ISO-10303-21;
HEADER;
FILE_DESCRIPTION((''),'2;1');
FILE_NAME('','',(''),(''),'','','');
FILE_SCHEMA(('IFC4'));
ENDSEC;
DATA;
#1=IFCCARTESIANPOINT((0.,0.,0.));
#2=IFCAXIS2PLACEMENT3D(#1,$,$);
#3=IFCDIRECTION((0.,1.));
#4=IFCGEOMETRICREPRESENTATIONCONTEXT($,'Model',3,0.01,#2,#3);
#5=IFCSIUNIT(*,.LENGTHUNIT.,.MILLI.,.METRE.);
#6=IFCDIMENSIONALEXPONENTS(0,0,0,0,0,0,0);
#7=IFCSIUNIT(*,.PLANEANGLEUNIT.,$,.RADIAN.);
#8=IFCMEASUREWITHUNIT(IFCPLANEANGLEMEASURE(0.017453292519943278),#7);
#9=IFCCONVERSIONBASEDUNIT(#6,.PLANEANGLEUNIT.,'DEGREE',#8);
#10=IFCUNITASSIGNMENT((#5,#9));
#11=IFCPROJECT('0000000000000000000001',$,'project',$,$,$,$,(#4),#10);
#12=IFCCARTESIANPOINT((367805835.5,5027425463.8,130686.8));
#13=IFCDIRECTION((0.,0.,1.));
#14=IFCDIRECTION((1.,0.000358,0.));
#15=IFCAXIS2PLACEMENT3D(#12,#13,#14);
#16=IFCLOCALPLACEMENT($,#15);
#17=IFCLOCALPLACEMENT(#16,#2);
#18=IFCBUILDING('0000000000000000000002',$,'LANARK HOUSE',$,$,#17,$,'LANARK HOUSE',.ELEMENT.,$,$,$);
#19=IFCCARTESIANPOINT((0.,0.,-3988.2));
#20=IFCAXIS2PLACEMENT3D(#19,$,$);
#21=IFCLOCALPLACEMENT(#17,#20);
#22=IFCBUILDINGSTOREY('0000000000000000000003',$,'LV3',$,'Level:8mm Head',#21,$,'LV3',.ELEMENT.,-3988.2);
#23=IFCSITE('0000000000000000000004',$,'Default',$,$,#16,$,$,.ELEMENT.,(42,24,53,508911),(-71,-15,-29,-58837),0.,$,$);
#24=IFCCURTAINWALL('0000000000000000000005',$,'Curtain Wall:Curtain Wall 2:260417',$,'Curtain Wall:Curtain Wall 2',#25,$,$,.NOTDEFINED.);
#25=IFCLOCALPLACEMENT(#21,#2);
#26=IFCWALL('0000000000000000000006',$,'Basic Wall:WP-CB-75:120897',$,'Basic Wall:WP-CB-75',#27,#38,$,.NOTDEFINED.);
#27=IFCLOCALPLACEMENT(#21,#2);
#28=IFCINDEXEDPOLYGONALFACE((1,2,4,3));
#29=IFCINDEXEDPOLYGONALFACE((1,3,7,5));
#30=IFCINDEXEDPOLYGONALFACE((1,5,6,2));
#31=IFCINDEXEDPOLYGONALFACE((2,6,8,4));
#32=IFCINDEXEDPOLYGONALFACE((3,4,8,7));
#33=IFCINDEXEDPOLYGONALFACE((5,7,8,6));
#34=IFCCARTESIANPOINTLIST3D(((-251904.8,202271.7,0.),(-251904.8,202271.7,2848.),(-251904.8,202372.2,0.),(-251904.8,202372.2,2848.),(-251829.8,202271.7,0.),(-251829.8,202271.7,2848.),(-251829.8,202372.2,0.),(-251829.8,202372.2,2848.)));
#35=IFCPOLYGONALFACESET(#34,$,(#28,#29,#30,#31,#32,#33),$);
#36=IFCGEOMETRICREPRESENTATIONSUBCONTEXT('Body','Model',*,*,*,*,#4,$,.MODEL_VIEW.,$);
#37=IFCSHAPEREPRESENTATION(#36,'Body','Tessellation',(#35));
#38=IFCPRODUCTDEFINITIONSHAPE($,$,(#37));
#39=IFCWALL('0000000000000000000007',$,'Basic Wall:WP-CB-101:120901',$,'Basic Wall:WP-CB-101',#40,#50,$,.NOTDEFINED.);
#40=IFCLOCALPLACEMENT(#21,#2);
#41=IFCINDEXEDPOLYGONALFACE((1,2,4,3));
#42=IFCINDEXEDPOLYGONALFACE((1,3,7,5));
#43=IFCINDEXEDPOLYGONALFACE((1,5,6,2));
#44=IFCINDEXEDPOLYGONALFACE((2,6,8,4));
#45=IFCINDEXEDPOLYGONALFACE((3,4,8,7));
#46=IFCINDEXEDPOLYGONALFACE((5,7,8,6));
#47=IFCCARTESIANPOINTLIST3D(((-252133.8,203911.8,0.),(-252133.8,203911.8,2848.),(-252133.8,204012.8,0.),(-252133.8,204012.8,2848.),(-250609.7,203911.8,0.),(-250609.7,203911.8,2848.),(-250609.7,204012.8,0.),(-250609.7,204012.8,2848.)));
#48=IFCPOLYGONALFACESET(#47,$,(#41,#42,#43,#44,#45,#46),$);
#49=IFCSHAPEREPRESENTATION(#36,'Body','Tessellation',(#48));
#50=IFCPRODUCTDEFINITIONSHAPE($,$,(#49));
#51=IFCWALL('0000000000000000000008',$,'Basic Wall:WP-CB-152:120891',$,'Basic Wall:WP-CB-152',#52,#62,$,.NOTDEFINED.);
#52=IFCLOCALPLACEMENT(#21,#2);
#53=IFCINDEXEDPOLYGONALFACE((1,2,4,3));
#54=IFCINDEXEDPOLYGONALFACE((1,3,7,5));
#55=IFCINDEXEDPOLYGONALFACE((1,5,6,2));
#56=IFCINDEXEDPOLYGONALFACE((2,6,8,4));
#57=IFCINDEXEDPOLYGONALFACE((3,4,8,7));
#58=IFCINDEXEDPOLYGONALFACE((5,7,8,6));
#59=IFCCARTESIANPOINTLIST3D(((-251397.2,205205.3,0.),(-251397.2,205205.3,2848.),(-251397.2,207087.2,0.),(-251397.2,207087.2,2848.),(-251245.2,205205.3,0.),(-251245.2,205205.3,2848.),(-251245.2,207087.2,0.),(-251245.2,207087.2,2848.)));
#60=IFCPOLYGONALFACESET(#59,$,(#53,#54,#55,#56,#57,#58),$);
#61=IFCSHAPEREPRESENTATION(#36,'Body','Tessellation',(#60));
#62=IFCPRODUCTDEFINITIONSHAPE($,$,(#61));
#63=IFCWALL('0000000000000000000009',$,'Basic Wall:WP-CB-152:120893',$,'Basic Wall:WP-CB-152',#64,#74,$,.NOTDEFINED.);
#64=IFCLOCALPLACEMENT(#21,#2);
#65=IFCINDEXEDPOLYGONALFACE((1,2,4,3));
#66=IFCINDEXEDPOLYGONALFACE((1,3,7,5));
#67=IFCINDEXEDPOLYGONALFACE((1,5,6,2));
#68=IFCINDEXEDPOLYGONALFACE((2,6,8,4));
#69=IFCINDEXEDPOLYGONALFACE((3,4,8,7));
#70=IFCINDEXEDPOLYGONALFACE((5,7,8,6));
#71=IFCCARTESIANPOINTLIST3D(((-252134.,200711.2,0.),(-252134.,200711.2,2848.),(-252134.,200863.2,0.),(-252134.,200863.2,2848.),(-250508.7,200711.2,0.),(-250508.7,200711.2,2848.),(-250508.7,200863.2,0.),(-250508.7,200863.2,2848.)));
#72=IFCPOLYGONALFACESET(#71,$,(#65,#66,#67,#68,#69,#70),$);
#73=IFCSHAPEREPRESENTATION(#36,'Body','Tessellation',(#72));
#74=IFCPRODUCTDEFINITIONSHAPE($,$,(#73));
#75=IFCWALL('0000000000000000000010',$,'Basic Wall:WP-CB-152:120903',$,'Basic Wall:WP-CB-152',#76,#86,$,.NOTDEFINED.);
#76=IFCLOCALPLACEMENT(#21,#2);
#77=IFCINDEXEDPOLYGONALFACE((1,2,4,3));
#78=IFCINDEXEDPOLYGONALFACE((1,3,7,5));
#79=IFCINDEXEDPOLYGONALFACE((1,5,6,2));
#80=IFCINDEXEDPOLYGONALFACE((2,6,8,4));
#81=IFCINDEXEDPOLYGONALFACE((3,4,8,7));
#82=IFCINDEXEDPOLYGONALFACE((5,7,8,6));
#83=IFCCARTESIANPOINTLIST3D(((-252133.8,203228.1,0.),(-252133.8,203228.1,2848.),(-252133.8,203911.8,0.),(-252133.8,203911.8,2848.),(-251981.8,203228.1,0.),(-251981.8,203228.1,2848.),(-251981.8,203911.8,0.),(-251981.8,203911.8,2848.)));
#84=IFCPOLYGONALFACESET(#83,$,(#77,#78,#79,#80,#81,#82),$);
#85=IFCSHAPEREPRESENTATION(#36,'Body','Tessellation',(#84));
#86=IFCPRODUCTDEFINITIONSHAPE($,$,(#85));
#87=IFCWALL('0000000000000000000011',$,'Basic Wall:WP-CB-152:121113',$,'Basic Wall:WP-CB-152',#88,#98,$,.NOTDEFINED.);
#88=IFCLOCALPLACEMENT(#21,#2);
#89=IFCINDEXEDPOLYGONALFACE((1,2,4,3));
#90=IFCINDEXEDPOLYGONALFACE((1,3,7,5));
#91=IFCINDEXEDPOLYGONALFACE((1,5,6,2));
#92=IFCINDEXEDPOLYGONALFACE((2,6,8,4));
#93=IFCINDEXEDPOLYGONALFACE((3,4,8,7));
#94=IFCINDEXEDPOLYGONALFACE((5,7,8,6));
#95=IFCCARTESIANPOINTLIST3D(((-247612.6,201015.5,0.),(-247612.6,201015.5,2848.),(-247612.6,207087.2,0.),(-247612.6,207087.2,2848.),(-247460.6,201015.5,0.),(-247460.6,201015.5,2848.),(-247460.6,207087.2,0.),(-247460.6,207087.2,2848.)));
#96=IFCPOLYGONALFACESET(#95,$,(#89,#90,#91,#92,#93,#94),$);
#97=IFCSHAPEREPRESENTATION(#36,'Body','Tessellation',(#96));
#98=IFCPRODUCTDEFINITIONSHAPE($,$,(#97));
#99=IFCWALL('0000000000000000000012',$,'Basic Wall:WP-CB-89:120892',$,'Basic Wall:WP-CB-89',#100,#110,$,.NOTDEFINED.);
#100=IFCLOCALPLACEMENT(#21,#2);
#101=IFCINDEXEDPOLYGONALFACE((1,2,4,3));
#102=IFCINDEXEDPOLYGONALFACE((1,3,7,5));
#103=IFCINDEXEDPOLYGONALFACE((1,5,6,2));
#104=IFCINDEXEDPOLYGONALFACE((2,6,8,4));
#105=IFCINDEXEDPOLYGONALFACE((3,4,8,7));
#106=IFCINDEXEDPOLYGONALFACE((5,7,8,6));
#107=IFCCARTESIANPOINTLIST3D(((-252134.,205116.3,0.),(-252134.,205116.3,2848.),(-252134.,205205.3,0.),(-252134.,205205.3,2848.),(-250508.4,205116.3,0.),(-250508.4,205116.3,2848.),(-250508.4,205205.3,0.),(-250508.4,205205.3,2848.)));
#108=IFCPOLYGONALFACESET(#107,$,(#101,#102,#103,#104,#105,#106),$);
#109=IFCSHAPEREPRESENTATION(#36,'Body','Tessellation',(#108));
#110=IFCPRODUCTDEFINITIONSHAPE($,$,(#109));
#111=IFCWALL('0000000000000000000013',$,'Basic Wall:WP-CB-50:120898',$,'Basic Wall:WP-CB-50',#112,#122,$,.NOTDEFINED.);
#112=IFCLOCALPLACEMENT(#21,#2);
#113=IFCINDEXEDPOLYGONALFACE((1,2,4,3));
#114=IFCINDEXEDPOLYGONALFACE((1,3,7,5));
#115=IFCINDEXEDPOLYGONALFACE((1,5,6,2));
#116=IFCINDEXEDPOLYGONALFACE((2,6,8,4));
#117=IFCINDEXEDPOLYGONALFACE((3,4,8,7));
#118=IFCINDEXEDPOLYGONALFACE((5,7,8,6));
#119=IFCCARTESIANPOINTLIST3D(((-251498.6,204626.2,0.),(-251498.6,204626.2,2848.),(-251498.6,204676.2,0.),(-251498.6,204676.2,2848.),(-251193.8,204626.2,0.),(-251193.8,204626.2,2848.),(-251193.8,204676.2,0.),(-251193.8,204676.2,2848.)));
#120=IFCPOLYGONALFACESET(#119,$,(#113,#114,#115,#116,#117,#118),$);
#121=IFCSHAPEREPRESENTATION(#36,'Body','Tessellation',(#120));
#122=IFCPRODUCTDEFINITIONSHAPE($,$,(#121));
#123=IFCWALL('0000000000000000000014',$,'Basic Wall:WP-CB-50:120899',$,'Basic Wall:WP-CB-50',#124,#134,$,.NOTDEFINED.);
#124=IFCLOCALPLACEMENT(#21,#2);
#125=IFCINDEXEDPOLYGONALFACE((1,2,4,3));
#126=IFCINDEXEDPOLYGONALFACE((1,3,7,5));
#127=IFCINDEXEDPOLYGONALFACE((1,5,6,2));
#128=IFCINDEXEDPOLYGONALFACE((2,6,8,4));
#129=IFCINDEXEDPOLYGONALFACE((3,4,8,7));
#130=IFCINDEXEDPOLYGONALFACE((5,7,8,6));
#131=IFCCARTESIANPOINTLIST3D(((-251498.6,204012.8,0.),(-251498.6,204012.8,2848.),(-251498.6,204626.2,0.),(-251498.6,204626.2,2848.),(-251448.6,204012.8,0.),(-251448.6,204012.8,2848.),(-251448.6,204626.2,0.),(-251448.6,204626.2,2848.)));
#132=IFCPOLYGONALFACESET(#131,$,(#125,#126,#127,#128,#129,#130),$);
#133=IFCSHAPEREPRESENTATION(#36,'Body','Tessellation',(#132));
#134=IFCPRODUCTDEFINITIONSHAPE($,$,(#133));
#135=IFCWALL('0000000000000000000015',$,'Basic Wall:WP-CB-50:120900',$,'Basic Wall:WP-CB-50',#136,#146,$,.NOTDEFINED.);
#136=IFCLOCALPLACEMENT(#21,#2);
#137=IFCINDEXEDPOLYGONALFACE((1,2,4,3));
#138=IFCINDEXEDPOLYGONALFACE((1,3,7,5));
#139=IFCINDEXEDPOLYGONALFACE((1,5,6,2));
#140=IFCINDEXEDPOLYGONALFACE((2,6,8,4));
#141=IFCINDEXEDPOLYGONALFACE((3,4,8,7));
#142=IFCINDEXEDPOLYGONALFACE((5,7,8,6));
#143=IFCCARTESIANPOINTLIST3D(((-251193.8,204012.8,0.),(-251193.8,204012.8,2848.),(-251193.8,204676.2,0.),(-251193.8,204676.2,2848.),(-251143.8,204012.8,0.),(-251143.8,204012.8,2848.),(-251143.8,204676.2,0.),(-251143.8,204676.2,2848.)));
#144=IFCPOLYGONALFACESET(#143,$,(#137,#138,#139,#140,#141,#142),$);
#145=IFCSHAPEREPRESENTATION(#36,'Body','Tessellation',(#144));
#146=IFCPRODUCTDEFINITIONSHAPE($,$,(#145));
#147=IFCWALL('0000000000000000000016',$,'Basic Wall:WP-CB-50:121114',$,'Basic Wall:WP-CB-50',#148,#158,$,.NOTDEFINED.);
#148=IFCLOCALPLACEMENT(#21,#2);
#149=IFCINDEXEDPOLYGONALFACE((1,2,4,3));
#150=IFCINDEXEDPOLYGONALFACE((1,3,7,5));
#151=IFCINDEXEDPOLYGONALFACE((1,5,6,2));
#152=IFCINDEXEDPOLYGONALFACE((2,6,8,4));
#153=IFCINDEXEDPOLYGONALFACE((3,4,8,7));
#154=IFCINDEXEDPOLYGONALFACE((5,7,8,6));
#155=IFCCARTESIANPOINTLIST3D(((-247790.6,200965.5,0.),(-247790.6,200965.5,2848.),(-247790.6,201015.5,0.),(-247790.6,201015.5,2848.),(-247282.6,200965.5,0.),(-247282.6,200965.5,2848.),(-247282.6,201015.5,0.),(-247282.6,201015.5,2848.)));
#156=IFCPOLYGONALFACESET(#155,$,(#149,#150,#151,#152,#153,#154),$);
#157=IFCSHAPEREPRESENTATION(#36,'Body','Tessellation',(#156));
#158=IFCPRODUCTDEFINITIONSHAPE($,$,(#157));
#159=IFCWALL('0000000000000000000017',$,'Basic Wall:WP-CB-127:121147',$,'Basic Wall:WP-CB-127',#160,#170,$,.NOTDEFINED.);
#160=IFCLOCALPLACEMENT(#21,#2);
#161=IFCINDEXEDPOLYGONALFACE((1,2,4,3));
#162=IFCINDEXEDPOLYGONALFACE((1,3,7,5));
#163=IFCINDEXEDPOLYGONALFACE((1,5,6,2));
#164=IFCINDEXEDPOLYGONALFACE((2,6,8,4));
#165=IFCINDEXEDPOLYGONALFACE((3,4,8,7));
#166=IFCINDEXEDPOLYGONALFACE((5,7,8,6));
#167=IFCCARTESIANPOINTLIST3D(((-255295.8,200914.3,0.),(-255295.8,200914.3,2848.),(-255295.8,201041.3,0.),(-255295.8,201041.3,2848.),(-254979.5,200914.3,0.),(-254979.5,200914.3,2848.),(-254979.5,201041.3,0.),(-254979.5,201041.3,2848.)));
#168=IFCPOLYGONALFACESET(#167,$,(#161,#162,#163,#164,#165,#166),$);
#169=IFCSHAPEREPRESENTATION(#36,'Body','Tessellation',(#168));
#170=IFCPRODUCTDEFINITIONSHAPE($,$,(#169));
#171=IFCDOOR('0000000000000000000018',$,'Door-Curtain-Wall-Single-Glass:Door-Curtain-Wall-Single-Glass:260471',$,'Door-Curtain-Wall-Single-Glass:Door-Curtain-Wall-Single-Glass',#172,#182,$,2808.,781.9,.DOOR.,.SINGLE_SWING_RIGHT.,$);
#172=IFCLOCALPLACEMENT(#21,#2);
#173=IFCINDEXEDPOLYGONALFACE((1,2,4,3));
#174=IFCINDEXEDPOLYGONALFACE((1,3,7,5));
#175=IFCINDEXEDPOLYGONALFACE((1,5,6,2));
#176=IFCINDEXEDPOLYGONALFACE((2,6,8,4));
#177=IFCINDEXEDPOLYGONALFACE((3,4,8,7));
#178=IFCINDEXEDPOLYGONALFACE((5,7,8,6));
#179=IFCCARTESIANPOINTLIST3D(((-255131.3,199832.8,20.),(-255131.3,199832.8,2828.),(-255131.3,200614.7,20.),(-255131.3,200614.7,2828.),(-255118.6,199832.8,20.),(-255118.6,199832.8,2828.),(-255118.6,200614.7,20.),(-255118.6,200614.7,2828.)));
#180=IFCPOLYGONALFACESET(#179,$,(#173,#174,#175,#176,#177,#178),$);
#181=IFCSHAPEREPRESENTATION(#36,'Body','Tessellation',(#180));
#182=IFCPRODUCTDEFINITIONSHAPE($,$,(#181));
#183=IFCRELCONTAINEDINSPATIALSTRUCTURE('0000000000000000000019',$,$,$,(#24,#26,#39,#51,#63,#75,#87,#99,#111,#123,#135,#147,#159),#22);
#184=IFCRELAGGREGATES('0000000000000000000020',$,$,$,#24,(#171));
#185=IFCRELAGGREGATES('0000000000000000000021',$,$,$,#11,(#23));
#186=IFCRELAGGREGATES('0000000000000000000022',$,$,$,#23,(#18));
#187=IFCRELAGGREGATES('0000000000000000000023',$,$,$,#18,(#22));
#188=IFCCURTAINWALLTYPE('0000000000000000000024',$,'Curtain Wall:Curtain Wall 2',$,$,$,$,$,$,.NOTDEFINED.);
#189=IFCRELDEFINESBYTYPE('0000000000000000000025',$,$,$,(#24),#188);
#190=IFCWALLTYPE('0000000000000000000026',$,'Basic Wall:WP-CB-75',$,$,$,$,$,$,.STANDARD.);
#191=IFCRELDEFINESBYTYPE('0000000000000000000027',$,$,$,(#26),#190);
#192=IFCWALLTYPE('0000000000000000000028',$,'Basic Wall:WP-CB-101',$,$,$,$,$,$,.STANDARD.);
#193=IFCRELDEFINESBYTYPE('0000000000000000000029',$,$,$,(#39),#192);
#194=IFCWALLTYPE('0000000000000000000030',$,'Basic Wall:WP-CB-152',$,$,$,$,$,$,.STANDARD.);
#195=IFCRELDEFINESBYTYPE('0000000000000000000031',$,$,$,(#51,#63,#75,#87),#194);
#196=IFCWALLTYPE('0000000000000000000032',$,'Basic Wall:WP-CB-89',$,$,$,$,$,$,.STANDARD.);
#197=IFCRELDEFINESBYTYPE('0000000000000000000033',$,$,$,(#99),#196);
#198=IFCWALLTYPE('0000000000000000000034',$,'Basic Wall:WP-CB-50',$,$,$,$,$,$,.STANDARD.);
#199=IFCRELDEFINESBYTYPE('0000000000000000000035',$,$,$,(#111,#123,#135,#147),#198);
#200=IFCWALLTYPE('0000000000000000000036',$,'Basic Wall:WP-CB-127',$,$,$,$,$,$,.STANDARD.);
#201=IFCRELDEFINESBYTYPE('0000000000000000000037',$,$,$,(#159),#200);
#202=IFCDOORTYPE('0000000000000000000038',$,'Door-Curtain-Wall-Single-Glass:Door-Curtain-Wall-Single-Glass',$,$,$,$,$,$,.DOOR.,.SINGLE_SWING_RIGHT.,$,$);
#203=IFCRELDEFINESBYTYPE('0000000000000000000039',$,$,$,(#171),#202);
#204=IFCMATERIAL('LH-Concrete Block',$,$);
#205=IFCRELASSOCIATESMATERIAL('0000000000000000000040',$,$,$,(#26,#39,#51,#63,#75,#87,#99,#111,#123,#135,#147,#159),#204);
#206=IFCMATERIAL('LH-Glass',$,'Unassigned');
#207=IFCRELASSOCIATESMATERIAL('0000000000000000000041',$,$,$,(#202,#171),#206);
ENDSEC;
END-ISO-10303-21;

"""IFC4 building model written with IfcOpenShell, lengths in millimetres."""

from ifc_helpers import new_model, entity, si_unit, converted_unit, direction, frame, origin, place, context, subcontext, project, spatial, indexed_curve, outline, extrude, source, transform, mapped, material, type_object, type_shapes, element, aggregate, save


model = new_model("IFC4")

# Units and contexts
model_context = context("Model", 3, precision=0.01, world=origin(), true_north=direction((0.0, 1.0)))
body_context = subcontext(model_context, "Body", "Model", "MODEL_VIEW")
ifc_project = project(units=[si_unit("LENGTHUNIT", "METRE", prefix="MILLI"), converted_unit("PLANEANGLEUNIT", "DEGREE", entity("IfcPlaneAngleMeasure", 0.017453292519943278), si_unit("PLANEANGLEUNIT", "RADIAN"), dimensions=[0, 0, 0, 0, 0, 0, 0])], contexts=[model_context])

# Site, building, storey
site_placement = place(None, frame((367805835.5, 5027425463.8, 130686.8), z_axis=(0.0, 0.0, 1.0), x_axis=(1.0, 0.000358, 0.0)))
site = spatial("IfcSite", under=ifc_project, at=site_placement, Name="Default", CompositionType="ELEMENT", RefLatitude=(42, 24, 53, 508911), RefLongitude=(-71, -15, -29, -58837), RefElevation=0.0)
building_placement = place(site_placement, origin())
building = spatial("IfcBuilding", under=site, at=building_placement, Name="LANARK HOUSE", LongName="LANARK HOUSE", CompositionType="ELEMENT")
storey_placement = place(building_placement, frame((0.0, 0.0, -3988.2)))
storey = spatial("IfcBuildingStorey", under=building, at=storey_placement, Name="LV3", ObjectType="Level:8mm Head", LongName="LV3", CompositionType="ELEMENT", Elevation=-3988.2)

# Curtain wall
curtain_wall_type = type_object("IfcCurtainWallType", Name="Curtain Wall:Curtain Wall 2", PredefinedType="NOTDEFINED")
curtain_wall_placement = place(storey_placement, frame((0.0, 0.0, 3988.2)))
curtain_wall = element("IfcCurtainWall", 1, at=curtain_wall_placement, inside=storey, type_object=curtain_wall_type, Name="Curtain Wall:Curtain Wall 2:260417", ObjectType="Curtain Wall:Curtain Wall 2", PredefinedType="NOTDEFINED")

# Walls
ifc_material_1 = material(Name="LH-Concrete Block")
wall_type_1 = type_object("IfcWallType", Name="Basic Wall:WP-CB-75", PredefinedType="STANDARD")
wall_1_placement = place(storey_placement, frame((-251867.3, 202372.2, 0.0), z_axis=(0.0, 0.0, 1.0), x_axis=(0.0, -1.0, 0.0)))
element("IfcWall", 2, at=wall_1_placement, inside=storey, type_object=wall_type_1, material=ifc_material_1, Name="Basic Wall:WP-CB-75:120897", ObjectType="Basic Wall:WP-CB-75", PredefinedType="NOTDEFINED", context=body_context, shape_type="SweptSolid", body=[
    extrude(outline(indexed_curve([(100.5, 37.5), (0.0, 37.5), (0.0, -37.5), (100.5, -37.5), (100.5, 37.5)], self_intersect=False)), origin(), (0.0, 0.0, 1.0), 2848.0),
])
wall_type_2 = type_object("IfcWallType", Name="Basic Wall:WP-CB-101", PredefinedType="STANDARD")
wall_2_placement = place(storey_placement, frame((-250609.7, 203962.3, 0.0), z_axis=(0.0, 0.0, 1.0), x_axis=(-1.0, 0.0, 0.0)))
element("IfcWall", 3, at=wall_2_placement, inside=storey, type_object=wall_type_2, material=ifc_material_1, Name="Basic Wall:WP-CB-101:120901", ObjectType="Basic Wall:WP-CB-101", PredefinedType="NOTDEFINED", context=body_context, shape_type="SweptSolid", body=[
    extrude(outline(indexed_curve([(1524.1, 50.5), (0.0, 50.5), (0.0, -50.5), (1524.1, -50.5), (1524.1, 50.5)], self_intersect=False)), origin(), (0.0, 0.0, 1.0), 2848.0),
])
wall_type_3 = type_object("IfcWallType", Name="Basic Wall:WP-CB-152", PredefinedType="STANDARD")
wall_3_placement = place(storey_placement, frame((-251321.2, 205205.3, 0.0), z_axis=(0.0, 0.0, 1.0), x_axis=(0.0, 1.0, 0.0)))
element("IfcWall", 4, at=wall_3_placement, inside=storey, type_object=wall_type_3, material=ifc_material_1, Name="Basic Wall:WP-CB-152:120891", ObjectType="Basic Wall:WP-CB-152", PredefinedType="NOTDEFINED", context=body_context, shape_type="SweptSolid", body=[
    extrude(outline(indexed_curve([(1881.9, 76.0), (0.0, 76.0), (0.0, -76.0), (1881.9, -76.0), (1881.9, 76.0)], self_intersect=False)), origin(), (0.0, 0.0, 1.0), 2848.0),
])
wall_4_placement = place(storey_placement, frame((-250508.7, 200787.2, 0.0), z_axis=(0.0, 0.0, 1.0), x_axis=(-1.0, 0.0, 0.0)))
element("IfcWall", 5, at=wall_4_placement, inside=storey, type_object=wall_type_3, material=ifc_material_1, Name="Basic Wall:WP-CB-152:120893", ObjectType="Basic Wall:WP-CB-152", PredefinedType="NOTDEFINED", context=body_context, shape_type="SweptSolid", body=[
    extrude(outline(indexed_curve([(1625.3, 76.0), (0.0, 76.0), (0.0, -76.0), (1625.3, -76.0), (1625.3, 76.0)], self_intersect=False)), origin(), (0.0, 0.0, 1.0), 2848.0),
])
wall_5_placement = place(storey_placement, frame((-252057.8, 203228.1, 0.0), z_axis=(0.0, 0.0, 1.0), x_axis=(0.0, 1.0, 0.0)))
element("IfcWall", 6, at=wall_5_placement, inside=storey, type_object=wall_type_3, material=ifc_material_1, Name="Basic Wall:WP-CB-152:120903", ObjectType="Basic Wall:WP-CB-152", PredefinedType="NOTDEFINED", context=body_context, shape_type="SweptSolid", body=[
    extrude(outline(indexed_curve([(683.7, 76.0), (0.0, 76.0), (0.0, -76.0), (683.7, -76.0), (683.7, 76.0)], self_intersect=False)), origin(), (0.0, 0.0, 1.0), 2848.0),
])
wall_6_placement = place(storey_placement, frame((-247536.6, 207087.2, 0.0), z_axis=(0.0, 0.0, 1.0), x_axis=(0.0, -1.0, 0.0)))
element("IfcWall", 7, at=wall_6_placement, inside=storey, type_object=wall_type_3, material=ifc_material_1, Name="Basic Wall:WP-CB-152:121113", ObjectType="Basic Wall:WP-CB-152", PredefinedType="NOTDEFINED", context=body_context, shape_type="SweptSolid", body=[
    extrude(outline(indexed_curve([(6071.8, 76.0), (0.0, 76.0), (0.0, -76.0), (6071.8, -76.0), (6071.8, 76.0)], self_intersect=False)), origin(), (0.0, 0.0, 1.0), 2848.0),
])
wall_type_4 = type_object("IfcWallType", Name="Basic Wall:WP-CB-89", PredefinedType="STANDARD")
wall_7_placement = place(storey_placement, frame((-250508.4, 205160.8, 0.0), z_axis=(0.0, 0.0, 1.0), x_axis=(-1.0, 0.0, 0.0)))
element("IfcWall", 8, at=wall_7_placement, inside=storey, type_object=wall_type_4, material=ifc_material_1, Name="Basic Wall:WP-CB-89:120892", ObjectType="Basic Wall:WP-CB-89", PredefinedType="NOTDEFINED", context=body_context, shape_type="SweptSolid", body=[
    extrude(outline(indexed_curve([(1625.6, 44.5), (0.0, 44.5), (0.0, -44.5), (1625.6, -44.5), (1625.6, 44.5)], self_intersect=False)), origin(), (0.0, 0.0, 1.0), 2848.0),
])
wall_type_5 = type_object("IfcWallType", Name="Basic Wall:WP-CB-50", PredefinedType="STANDARD")
wall_8_placement = place(storey_placement, frame((-251498.6, 204651.2, 0.0)))
element("IfcWall", 9, at=wall_8_placement, inside=storey, type_object=wall_type_5, material=ifc_material_1, Name="Basic Wall:WP-CB-50:120898", ObjectType="Basic Wall:WP-CB-50", PredefinedType="NOTDEFINED", context=body_context, shape_type="SweptSolid", body=[
    extrude(outline(indexed_curve([(304.8, 25.0), (0.0, 25.0), (0.0, -25.0), (304.8, -25.0), (304.8, 25.0)], self_intersect=False)), origin(), (0.0, 0.0, 1.0), 2848.0),
])
wall_9_placement = place(storey_placement, frame((-251473.6, 204012.8, 0.0), z_axis=(0.0, 0.0, 1.0), x_axis=(0.0, 1.0, 0.0)))
element("IfcWall", 10, at=wall_9_placement, inside=storey, type_object=wall_type_5, material=ifc_material_1, Name="Basic Wall:WP-CB-50:120899", ObjectType="Basic Wall:WP-CB-50", PredefinedType="NOTDEFINED", context=body_context, shape_type="SweptSolid", body=[
    extrude(outline(indexed_curve([(613.5, 25.0), (0.0, 25.0), (0.0, -25.0), (613.5, -25.0), (613.5, 25.0)], self_intersect=False)), origin(), (0.0, 0.0, 1.0), 2848.0),
])
wall_10_placement = place(storey_placement, frame((-251168.8, 204012.8, 0.0), z_axis=(0.0, 0.0, 1.0), x_axis=(0.0, 1.0, 0.0)))
element("IfcWall", 11, at=wall_10_placement, inside=storey, type_object=wall_type_5, material=ifc_material_1, Name="Basic Wall:WP-CB-50:120900", ObjectType="Basic Wall:WP-CB-50", PredefinedType="NOTDEFINED", context=body_context, shape_type="SweptSolid", body=[
    extrude(outline(indexed_curve([(663.5, 25.0), (0.0, 25.0), (0.0, -25.0), (663.5, -25.0), (663.5, 25.0)], self_intersect=False)), origin(), (0.0, 0.0, 1.0), 2848.0),
])
wall_11_placement = place(storey_placement, frame((-247790.6, 200990.5, 0.0)))
element("IfcWall", 12, at=wall_11_placement, inside=storey, type_object=wall_type_5, material=ifc_material_1, Name="Basic Wall:WP-CB-50:121114", ObjectType="Basic Wall:WP-CB-50", PredefinedType="NOTDEFINED", context=body_context, shape_type="SweptSolid", body=[
    extrude(outline(indexed_curve([(508.0, 25.0), (0.0, 25.0), (0.0, -25.0), (508.0, -25.0), (508.0, 25.0)], self_intersect=False)), origin(), (0.0, 0.0, 1.0), 2848.0),
])
wall_type_6 = type_object("IfcWallType", Name="Basic Wall:WP-CB-127", PredefinedType="STANDARD")
wall_12_placement = place(storey_placement, frame((-255295.8, 200977.8, 0.0)))
element("IfcWall", 13, at=wall_12_placement, inside=storey, type_object=wall_type_6, material=ifc_material_1, Name="Basic Wall:WP-CB-127:121147", ObjectType="Basic Wall:WP-CB-127", PredefinedType="NOTDEFINED", context=body_context, shape_type="SweptSolid", body=[
    extrude(outline(indexed_curve([(316.2, 63.5), (0.0, 63.5), (0.0, -63.5), (316.2, -63.5), (316.2, 63.5)], self_intersect=False)), origin(), (0.0, 0.0, 1.0), 2848.0),
])

# Door
ifc_material_2 = material(Name="LH-Glass", Category="Unassigned")
door_type = type_object("IfcDoorType", Name="Door-Curtain-Wall-Single-Glass:Door-Curtain-Wall-Single-Glass", OperationType="SINGLE_SWING_RIGHT", PredefinedType="DOOR", material=ifc_material_2)
shared_shape_1 = source(origin(), body_context, "Body", "SweptSolid", [
    extrude(outline(indexed_curve([(-390.9, -6.4), (390.9, -6.4), (390.9, 6.4), (-390.9, 6.4), (-390.9, -6.4)], self_intersect=False)), frame((0.0, 44.5, 0.0), z_axis=(0.0, 0.0, 1.0), x_axis=(-1.0, 0.0, 0.0)), (0.0, 0.0, 1.0), 2808.0),
])
type_shapes(door_type, [shared_shape_1])
door_placement = place(curtain_wall_placement, frame((-255080.5, 200223.8, -3968.2), z_axis=(0.0, 0.0, 1.0), x_axis=(0.0, 1.0, 0.0)))
door = element("IfcDoor", 14, at=door_placement, type_object=door_type, material=ifc_material_2, Name="Door-Curtain-Wall-Single-Glass:Door-Curtain-Wall-Single-Glass:260471", ObjectType="Door-Curtain-Wall-Single-Glass:Door-Curtain-Wall-Single-Glass", OperationType="SINGLE_SWING_RIGHT", OverallHeight=2808.0, OverallWidth=781.9, PredefinedType="DOOR", context=body_context, shape_type="MappedRepresentation", body=[
    mapped(shared_shape_1, transform((0.0, 0.0, 0.0), scale=1.0)),
])
aggregate(curtain_wall, [door])

save(model, "model.ifc")
